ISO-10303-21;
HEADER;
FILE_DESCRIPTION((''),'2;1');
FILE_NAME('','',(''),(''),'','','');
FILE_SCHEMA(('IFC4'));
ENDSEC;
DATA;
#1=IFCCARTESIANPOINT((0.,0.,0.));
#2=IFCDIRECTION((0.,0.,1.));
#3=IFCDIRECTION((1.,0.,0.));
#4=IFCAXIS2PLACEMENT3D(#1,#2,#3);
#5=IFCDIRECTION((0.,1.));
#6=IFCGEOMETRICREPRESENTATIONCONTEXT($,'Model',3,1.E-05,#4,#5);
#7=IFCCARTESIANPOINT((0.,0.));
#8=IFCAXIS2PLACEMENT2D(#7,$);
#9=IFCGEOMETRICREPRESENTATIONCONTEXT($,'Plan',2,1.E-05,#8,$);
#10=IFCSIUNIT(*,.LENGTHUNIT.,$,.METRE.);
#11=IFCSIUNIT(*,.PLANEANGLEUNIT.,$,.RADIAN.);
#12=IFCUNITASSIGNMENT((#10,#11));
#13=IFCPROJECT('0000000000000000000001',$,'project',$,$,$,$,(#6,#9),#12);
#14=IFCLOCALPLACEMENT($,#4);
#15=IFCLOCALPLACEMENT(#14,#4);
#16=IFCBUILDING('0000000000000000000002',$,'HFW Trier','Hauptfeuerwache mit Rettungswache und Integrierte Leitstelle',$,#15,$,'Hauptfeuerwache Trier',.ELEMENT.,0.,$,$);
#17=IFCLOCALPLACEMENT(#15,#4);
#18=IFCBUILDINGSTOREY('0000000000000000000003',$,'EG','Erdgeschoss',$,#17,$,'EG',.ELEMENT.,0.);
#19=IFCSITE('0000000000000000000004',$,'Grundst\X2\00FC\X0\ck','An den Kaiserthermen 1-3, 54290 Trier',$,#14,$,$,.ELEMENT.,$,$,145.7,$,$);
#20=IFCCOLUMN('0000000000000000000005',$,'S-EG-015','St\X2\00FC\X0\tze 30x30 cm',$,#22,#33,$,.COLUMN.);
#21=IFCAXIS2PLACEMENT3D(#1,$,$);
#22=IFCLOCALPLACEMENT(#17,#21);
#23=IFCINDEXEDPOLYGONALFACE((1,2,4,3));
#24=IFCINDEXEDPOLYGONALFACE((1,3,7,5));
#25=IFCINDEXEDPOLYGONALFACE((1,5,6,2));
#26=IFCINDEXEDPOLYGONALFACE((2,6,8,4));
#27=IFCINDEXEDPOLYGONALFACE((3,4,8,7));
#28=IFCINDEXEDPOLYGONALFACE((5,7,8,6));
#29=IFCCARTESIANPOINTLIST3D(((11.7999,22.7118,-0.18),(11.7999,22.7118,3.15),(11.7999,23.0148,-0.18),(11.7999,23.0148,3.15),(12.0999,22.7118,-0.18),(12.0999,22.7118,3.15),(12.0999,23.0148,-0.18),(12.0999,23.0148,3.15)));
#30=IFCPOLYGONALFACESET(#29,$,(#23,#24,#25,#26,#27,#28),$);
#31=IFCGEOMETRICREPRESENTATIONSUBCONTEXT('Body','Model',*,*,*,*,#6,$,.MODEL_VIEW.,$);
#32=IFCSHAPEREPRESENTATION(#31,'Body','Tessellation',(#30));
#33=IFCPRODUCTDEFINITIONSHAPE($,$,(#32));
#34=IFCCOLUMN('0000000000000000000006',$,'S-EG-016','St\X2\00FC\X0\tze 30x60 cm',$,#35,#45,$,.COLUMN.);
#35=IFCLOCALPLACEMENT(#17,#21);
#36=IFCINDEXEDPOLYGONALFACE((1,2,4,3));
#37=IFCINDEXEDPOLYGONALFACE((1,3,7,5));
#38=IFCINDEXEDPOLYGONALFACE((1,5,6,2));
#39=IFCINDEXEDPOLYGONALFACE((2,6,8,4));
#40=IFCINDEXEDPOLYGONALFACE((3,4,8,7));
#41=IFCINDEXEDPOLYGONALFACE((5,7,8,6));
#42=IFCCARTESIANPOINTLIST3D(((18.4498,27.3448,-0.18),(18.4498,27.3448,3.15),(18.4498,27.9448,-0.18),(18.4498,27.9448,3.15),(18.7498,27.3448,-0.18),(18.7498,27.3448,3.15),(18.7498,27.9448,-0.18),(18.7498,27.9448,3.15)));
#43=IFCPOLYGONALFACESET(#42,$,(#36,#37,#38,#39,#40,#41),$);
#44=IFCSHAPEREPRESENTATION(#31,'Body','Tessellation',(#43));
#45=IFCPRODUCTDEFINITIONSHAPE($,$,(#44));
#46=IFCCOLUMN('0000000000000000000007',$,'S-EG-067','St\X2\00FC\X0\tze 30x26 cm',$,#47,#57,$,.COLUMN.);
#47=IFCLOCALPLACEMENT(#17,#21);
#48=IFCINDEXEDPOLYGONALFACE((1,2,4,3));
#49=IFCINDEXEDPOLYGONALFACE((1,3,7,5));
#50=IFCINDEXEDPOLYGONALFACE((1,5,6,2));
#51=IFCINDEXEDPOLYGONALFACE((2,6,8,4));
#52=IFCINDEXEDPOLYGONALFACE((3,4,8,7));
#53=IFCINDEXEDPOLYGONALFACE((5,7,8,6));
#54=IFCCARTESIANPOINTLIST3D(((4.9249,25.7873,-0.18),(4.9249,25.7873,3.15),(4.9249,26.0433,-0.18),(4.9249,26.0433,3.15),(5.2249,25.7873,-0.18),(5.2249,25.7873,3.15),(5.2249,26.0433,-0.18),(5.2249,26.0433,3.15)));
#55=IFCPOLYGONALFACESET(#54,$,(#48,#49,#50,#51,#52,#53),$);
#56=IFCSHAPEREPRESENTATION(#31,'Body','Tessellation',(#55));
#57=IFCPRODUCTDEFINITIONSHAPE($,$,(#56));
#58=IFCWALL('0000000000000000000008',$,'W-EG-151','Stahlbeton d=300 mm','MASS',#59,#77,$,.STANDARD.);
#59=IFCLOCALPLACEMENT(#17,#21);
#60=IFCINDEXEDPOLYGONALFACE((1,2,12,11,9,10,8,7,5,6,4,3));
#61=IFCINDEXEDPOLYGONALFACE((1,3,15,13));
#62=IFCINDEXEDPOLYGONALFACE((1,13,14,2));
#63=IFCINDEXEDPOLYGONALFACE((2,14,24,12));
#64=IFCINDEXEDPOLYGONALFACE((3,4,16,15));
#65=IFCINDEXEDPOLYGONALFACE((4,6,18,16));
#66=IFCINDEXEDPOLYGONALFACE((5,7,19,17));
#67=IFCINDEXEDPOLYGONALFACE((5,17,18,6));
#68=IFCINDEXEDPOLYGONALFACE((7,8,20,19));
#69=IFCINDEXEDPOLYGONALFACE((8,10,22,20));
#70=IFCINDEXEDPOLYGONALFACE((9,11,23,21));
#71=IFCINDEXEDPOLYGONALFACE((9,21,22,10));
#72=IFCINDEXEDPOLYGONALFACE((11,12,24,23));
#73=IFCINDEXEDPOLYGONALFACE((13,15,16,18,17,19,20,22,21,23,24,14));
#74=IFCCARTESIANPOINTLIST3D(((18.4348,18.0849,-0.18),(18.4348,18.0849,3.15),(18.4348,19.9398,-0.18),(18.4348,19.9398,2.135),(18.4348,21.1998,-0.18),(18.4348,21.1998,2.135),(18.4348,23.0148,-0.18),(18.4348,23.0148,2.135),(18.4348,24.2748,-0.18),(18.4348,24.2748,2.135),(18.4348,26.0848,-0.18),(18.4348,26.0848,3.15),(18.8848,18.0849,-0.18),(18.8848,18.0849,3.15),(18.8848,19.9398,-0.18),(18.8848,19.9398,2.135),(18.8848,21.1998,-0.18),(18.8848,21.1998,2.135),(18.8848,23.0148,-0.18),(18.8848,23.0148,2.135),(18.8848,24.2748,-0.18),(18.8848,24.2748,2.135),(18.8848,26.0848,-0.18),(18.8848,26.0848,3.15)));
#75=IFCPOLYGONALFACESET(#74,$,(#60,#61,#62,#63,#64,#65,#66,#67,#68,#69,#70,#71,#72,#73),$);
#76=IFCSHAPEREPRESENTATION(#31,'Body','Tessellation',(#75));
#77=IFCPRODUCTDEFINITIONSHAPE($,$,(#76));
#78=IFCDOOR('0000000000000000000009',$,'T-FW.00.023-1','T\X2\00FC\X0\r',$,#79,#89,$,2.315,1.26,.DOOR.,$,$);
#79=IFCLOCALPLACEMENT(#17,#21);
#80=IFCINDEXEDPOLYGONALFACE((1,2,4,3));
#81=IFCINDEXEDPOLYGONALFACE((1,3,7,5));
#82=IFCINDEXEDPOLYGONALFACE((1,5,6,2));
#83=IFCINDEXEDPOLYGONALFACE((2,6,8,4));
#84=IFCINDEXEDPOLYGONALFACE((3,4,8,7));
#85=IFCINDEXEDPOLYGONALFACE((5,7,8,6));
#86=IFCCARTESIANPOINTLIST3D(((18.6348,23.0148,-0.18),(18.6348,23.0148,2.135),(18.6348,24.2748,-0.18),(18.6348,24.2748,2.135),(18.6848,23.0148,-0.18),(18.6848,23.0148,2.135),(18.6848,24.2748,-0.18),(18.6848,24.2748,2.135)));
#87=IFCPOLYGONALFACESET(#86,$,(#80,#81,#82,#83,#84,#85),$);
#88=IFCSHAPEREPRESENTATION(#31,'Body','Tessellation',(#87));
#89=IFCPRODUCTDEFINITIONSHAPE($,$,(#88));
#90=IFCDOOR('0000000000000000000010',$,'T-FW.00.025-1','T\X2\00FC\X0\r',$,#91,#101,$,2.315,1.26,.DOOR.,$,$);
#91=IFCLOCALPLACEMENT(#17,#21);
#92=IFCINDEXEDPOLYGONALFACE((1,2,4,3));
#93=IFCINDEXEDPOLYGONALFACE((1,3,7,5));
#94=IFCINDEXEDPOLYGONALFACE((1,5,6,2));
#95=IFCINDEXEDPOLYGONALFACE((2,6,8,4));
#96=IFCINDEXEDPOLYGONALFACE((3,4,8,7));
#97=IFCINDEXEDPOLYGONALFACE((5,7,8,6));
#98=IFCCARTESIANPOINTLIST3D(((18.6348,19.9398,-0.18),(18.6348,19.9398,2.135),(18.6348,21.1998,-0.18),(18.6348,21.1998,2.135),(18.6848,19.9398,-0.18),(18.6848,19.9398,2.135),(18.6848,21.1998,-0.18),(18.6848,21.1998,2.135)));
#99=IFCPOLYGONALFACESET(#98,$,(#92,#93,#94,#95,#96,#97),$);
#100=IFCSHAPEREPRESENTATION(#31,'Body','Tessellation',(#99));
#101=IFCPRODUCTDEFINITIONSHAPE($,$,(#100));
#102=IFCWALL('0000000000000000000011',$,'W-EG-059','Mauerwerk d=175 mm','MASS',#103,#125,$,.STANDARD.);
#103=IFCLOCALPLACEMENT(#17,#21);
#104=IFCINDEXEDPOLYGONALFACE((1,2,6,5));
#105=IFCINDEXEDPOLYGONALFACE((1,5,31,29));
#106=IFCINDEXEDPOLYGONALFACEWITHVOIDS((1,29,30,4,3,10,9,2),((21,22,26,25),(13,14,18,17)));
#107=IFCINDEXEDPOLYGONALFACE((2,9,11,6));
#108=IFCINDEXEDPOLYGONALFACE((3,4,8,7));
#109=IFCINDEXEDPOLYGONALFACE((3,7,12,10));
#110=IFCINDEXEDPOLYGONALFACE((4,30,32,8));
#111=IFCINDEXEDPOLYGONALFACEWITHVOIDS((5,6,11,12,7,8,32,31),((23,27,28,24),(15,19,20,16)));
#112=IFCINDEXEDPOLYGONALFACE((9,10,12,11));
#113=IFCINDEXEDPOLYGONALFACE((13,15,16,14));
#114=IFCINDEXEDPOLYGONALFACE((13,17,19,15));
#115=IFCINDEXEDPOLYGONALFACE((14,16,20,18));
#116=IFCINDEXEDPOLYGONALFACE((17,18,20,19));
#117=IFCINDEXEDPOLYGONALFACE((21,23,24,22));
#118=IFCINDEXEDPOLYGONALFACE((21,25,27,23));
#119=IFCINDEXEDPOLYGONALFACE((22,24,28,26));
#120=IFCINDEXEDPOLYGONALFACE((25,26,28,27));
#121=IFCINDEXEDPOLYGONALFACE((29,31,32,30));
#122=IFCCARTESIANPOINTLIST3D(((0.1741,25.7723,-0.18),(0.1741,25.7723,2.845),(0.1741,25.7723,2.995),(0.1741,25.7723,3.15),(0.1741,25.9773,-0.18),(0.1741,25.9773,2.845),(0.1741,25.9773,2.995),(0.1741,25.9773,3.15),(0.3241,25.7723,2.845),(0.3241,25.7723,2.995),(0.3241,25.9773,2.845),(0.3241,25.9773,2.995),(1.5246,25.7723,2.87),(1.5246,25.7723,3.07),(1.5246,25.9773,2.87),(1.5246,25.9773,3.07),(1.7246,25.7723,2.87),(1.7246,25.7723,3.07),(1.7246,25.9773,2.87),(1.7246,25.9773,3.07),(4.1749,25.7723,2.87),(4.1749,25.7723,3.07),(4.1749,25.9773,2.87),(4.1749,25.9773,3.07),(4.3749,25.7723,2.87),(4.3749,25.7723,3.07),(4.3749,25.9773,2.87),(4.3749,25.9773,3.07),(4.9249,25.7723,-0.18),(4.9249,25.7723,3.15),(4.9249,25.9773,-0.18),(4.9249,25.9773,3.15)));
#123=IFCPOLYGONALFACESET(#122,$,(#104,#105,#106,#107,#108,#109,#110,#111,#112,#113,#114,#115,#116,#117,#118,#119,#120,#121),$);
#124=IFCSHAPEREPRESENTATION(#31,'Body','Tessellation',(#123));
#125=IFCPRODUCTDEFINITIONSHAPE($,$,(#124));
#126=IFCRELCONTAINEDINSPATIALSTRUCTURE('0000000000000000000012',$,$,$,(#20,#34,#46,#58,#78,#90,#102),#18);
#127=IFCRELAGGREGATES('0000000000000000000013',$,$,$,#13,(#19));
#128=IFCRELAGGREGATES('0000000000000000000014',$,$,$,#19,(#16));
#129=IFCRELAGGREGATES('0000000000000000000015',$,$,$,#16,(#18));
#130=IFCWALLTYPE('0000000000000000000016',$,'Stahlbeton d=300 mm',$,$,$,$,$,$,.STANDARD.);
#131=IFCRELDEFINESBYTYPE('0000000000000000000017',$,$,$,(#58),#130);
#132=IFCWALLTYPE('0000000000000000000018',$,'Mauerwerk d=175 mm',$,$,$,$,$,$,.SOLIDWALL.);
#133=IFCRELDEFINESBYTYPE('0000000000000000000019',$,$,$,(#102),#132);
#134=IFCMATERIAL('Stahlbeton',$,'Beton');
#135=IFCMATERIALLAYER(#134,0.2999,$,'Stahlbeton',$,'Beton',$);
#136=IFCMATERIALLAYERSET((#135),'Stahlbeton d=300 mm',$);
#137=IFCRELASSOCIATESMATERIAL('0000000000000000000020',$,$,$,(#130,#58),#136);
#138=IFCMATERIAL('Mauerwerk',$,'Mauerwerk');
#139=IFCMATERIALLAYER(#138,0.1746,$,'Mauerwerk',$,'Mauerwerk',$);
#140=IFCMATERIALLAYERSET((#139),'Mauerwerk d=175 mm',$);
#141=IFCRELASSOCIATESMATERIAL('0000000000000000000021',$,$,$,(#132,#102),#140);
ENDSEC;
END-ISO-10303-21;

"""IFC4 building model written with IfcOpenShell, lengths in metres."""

from ifc_helpers import new_model, si_unit, direction, frame, frame_2d, origin_with_axes, origin_2d, place, context, subcontext, project, spatial, rectangle, extrude, material, layer, layer_set, layer_usage, type_object, element, fill, save


model = new_model("IFC4")

# Units and contexts
model_context = context("Model", 3, precision=1e-05, world=origin_with_axes(), true_north=direction((0.0, 1.0)))
plan_context = context("Plan", 2, precision=1e-05, world=origin_2d())
body_context = subcontext(model_context, "Body", "Model", "MODEL_VIEW")
ifc_project = project(units=[si_unit("LENGTHUNIT", "METRE"), si_unit("PLANEANGLEUNIT", "RADIAN")], contexts=[model_context, plan_context])

# Site, building, storey
site_placement = place(None, origin_with_axes())
site = spatial("IfcSite", under=ifc_project, at=site_placement, Name="Grundstück", Description="An den Kaiserthermen 1-3, 54290 Trier", CompositionType="ELEMENT", RefElevation=145.7)
building_placement = place(site_placement, origin_with_axes())
building = spatial("IfcBuilding", under=site, at=building_placement, Name="HFW Trier", Description="Hauptfeuerwache mit Rettungswache und Integrierte Leitstelle", LongName="Hauptfeuerwache Trier", CompositionType="ELEMENT", ElevationOfRefHeight=0.0)
storey_placement = place(building_placement, origin_with_axes())
storey = spatial("IfcBuildingStorey", under=building, at=storey_placement, Name="EG", Description="Erdgeschoss", LongName="EG", CompositionType="ELEMENT", Elevation=0.0)

# Columns
column_1_placement = place(storey_placement, frame((11.7999, 22.8633, -0.18), z_axis=(0.0, 0.0, 1.0), x_axis=(1.0, 0.0, 0.0)))
element("IfcColumn", 1, at=column_1_placement, inside=storey, Name="S-EG-015", Description="Stütze 30x30 cm", PredefinedType="COLUMN", context=body_context, shape_type="SweptSolid", body=[
    extrude(rectangle(XDim=0.3, YDim=0.303, at=frame_2d((0.15, 0.0))), origin_with_axes(), (0.0, 0.0, 1.0), 3.33),
])
column_2_placement = place(storey_placement, frame((18.4498, 27.6448, -0.18), z_axis=(0.0, 0.0, 1.0), x_axis=(1.0, 0.0, 0.0)))
element("IfcColumn", 2, at=column_2_placement, inside=storey, Name="S-EG-016", Description="Stütze 30x60 cm", PredefinedType="COLUMN", context=body_context, shape_type="SweptSolid", body=[
    extrude(rectangle(XDim=0.3, YDim=0.6, at=frame_2d((0.15, 0.0))), origin_with_axes(), (0.0, 0.0, 1.0), 3.33),
])
column_3_placement = place(storey_placement, frame((4.9249, 25.9153, -0.18), z_axis=(0.0, 0.0, 1.0), x_axis=(1.0, 0.0, 0.0)))
element("IfcColumn", 3, at=column_3_placement, inside=storey, Name="S-EG-067", Description="Stütze 30x26 cm", PredefinedType="COLUMN", context=body_context, shape_type="SweptSolid", body=[
    extrude(rectangle(XDim=0.3, YDim=0.256, at=frame_2d((0.15, 0.0))), origin_with_axes(), (0.0, 0.0, 1.0), 3.33),
])

# Wall, openings, doors
ifc_material_1 = material(Name="Stahlbeton", Category="Beton")
ifc_layer_1 = layer(ifc_material_1, 0.2999, Name="Stahlbeton", Category="Beton")
ifc_layer_set_1 = layer_set([ifc_layer_1], Name="Stahlbeton d=300 mm")
ifc_layer_usage_1 = layer_usage(ifc_layer_set_1, "AXIS2", "POSITIVE", -0.225)
wall_type_1 = type_object("IfcWallType", Name="Stahlbeton d=300 mm", PredefinedType="STANDARD", material=ifc_layer_set_1)
wall_1_placement = place(storey_placement, frame((18.6598, 26.0848, -0.18), z_axis=(0.0, 0.0, 1.0), x_axis=(0.0, -1.0, 0.0)))
wall_1 = element("IfcWall", 4, at=wall_1_placement, inside=storey, type_object=wall_type_1, material=ifc_layer_usage_1, Name="W-EG-151", Description="Stahlbeton d=300 mm", ObjectType="MASS", PredefinedType="STANDARD", context=body_context, shape_type="SweptSolid", body=[
    extrude(rectangle(XDim=7.9999, YDim=0.45, at=frame_2d((4.0, 0.0))), origin_with_axes(), (0.0, 0.0, 1.0), 3.33),
])
opening_1_placement = place(wall_1_placement, frame((1.81, 0.0, 0.0), z_axis=(0.0, 0.0, 1.0), x_axis=(1.0, 0.0, 0.0)))
opening_1 = element("IfcOpeningElement", 5, at=opening_1_placement, cuts=wall_1, PredefinedType="OPENING", context=body_context, shape_type="SweptSolid", body=[
    extrude(rectangle(XDim=1.26, YDim=0.55, at=frame_2d((0.63, 0.0))), origin_with_axes(), (0.0, 0.0, 1.0), 2.315),
])
opening_2_placement = place(wall_1_placement, frame((4.885, 0.0, 0.0), z_axis=(0.0, 0.0, 1.0), x_axis=(1.0, 0.0, 0.0)))
opening_2 = element("IfcOpeningElement", 6, at=opening_2_placement, cuts=wall_1, PredefinedType="OPENING", context=body_context, shape_type="SweptSolid", body=[
    extrude(rectangle(XDim=1.26, YDim=0.55, at=frame_2d((0.63, 0.0))), origin_with_axes(), (0.0, 0.0, 1.0), 2.315),
])
door_1_placement = place(wall_1_placement, frame((1.81, 0.0, 0.0), z_axis=(0.0, 0.0, 1.0), x_axis=(1.0, 0.0, 0.0)))
door_1 = element("IfcDoor", 7, at=door_1_placement, inside=storey, Name="T-FW.00.023-1", Description="Tür", OverallHeight=2.315, OverallWidth=1.26, PredefinedType="DOOR", context=body_context, shape_type="SweptSolid", body=[
    extrude(rectangle(XDim=1.26, YDim=0.05, at=frame_2d((0.63, 0.0))), origin_with_axes(), (0.0, 0.0, 1.0), 2.315),
])
fill(opening_1, door_1)
door_2_placement = place(wall_1_placement, frame((4.885, 0.0, 0.0), z_axis=(0.0, 0.0, 1.0), x_axis=(1.0, 0.0, 0.0)))
door_2 = element("IfcDoor", 8, at=door_2_placement, inside=storey, Name="T-FW.00.025-1", Description="Tür", OverallHeight=2.315, OverallWidth=1.26, PredefinedType="DOOR", context=body_context, shape_type="SweptSolid", body=[
    extrude(rectangle(XDim=1.26, YDim=0.05, at=frame_2d((0.63, 0.0))), origin_with_axes(), (0.0, 0.0, 1.0), 2.315),
])
fill(opening_2, door_2)

# Wall, openings
ifc_material_2 = material(Name="Mauerwerk", Category="Mauerwerk")
ifc_layer_2 = layer(ifc_material_2, 0.1746, Name="Mauerwerk", Category="Mauerwerk")
ifc_layer_set_2 = layer_set([ifc_layer_2], Name="Mauerwerk d=175 mm")
ifc_layer_usage_2 = layer_usage(ifc_layer_set_2, "AXIS2", "POSITIVE", -0.1025)
wall_type_2 = type_object("IfcWallType", Name="Mauerwerk d=175 mm", PredefinedType="SOLIDWALL", material=ifc_layer_set_2)
wall_2_placement = place(storey_placement, frame((0.1741, 25.8748, -0.18), z_axis=(0.0, 0.0, 1.0), x_axis=(1.0, 0.0, 0.0)))
wall_2 = element("IfcWall", 9, at=wall_2_placement, inside=storey, type_object=wall_type_2, material=ifc_layer_usage_2, Name="W-EG-059", Description="Mauerwerk d=175 mm", ObjectType="MASS", PredefinedType="STANDARD", context=body_context, shape_type="SweptSolid", body=[
    extrude(rectangle(XDim=4.7508, YDim=0.205, at=frame_2d((2.3754, 0.0))), origin_with_axes(), (0.0, 0.0, 1.0), 3.33),
])
opening_3_placement = place(wall_2_placement, origin_with_axes())
element("IfcOpeningElement", 10, at=opening_3_placement, cuts=wall_2, ObjectType="Wanddurchbruch", PredefinedType="OPENING", context=body_context, shape_type="SweptSolid", body=[
    extrude(rectangle(XDim=0.15, YDim=0.305, at=frame_2d((0.075, 0.0))), frame((0.0, 0.0, 3.025), z_axis=(0.0, 0.0, 1.0), x_axis=(1.0, 0.0, 0.0)), (0.0, 0.0, 1.0), 0.15),
])
opening_4_placement = place(wall_2_placement, origin_with_axes())
element("IfcOpeningElement", 11, at=opening_4_placement, cuts=wall_2, ObjectType="Wanddurchbruch", PredefinedType="OPENING", context=body_context, shape_type="SweptSolid", body=[
    extrude(rectangle(XDim=0.2, YDim=0.305, at=frame_2d((1.4505, 0.0))), frame((0.0, 0.0, 3.05), z_axis=(0.0, 0.0, 1.0), x_axis=(1.0, 0.0, 0.0)), (0.0, 0.0, 1.0), 0.2),
])
opening_5_placement = place(wall_2_placement, origin_with_axes())
element("IfcOpeningElement", 12, at=opening_5_placement, cuts=wall_2, ObjectType="Wanddurchbruch", PredefinedType="OPENING", context=body_context, shape_type="SweptSolid", body=[
    extrude(rectangle(XDim=0.2, YDim=0.305, at=frame_2d((4.1008, 0.0))), frame((0.0, 0.0, 3.05), z_axis=(0.0, 0.0, 1.0), x_axis=(1.0, 0.0, 0.0)), (0.0, 0.0, 1.0), 0.2),
])

save(model, "model.ifc")
